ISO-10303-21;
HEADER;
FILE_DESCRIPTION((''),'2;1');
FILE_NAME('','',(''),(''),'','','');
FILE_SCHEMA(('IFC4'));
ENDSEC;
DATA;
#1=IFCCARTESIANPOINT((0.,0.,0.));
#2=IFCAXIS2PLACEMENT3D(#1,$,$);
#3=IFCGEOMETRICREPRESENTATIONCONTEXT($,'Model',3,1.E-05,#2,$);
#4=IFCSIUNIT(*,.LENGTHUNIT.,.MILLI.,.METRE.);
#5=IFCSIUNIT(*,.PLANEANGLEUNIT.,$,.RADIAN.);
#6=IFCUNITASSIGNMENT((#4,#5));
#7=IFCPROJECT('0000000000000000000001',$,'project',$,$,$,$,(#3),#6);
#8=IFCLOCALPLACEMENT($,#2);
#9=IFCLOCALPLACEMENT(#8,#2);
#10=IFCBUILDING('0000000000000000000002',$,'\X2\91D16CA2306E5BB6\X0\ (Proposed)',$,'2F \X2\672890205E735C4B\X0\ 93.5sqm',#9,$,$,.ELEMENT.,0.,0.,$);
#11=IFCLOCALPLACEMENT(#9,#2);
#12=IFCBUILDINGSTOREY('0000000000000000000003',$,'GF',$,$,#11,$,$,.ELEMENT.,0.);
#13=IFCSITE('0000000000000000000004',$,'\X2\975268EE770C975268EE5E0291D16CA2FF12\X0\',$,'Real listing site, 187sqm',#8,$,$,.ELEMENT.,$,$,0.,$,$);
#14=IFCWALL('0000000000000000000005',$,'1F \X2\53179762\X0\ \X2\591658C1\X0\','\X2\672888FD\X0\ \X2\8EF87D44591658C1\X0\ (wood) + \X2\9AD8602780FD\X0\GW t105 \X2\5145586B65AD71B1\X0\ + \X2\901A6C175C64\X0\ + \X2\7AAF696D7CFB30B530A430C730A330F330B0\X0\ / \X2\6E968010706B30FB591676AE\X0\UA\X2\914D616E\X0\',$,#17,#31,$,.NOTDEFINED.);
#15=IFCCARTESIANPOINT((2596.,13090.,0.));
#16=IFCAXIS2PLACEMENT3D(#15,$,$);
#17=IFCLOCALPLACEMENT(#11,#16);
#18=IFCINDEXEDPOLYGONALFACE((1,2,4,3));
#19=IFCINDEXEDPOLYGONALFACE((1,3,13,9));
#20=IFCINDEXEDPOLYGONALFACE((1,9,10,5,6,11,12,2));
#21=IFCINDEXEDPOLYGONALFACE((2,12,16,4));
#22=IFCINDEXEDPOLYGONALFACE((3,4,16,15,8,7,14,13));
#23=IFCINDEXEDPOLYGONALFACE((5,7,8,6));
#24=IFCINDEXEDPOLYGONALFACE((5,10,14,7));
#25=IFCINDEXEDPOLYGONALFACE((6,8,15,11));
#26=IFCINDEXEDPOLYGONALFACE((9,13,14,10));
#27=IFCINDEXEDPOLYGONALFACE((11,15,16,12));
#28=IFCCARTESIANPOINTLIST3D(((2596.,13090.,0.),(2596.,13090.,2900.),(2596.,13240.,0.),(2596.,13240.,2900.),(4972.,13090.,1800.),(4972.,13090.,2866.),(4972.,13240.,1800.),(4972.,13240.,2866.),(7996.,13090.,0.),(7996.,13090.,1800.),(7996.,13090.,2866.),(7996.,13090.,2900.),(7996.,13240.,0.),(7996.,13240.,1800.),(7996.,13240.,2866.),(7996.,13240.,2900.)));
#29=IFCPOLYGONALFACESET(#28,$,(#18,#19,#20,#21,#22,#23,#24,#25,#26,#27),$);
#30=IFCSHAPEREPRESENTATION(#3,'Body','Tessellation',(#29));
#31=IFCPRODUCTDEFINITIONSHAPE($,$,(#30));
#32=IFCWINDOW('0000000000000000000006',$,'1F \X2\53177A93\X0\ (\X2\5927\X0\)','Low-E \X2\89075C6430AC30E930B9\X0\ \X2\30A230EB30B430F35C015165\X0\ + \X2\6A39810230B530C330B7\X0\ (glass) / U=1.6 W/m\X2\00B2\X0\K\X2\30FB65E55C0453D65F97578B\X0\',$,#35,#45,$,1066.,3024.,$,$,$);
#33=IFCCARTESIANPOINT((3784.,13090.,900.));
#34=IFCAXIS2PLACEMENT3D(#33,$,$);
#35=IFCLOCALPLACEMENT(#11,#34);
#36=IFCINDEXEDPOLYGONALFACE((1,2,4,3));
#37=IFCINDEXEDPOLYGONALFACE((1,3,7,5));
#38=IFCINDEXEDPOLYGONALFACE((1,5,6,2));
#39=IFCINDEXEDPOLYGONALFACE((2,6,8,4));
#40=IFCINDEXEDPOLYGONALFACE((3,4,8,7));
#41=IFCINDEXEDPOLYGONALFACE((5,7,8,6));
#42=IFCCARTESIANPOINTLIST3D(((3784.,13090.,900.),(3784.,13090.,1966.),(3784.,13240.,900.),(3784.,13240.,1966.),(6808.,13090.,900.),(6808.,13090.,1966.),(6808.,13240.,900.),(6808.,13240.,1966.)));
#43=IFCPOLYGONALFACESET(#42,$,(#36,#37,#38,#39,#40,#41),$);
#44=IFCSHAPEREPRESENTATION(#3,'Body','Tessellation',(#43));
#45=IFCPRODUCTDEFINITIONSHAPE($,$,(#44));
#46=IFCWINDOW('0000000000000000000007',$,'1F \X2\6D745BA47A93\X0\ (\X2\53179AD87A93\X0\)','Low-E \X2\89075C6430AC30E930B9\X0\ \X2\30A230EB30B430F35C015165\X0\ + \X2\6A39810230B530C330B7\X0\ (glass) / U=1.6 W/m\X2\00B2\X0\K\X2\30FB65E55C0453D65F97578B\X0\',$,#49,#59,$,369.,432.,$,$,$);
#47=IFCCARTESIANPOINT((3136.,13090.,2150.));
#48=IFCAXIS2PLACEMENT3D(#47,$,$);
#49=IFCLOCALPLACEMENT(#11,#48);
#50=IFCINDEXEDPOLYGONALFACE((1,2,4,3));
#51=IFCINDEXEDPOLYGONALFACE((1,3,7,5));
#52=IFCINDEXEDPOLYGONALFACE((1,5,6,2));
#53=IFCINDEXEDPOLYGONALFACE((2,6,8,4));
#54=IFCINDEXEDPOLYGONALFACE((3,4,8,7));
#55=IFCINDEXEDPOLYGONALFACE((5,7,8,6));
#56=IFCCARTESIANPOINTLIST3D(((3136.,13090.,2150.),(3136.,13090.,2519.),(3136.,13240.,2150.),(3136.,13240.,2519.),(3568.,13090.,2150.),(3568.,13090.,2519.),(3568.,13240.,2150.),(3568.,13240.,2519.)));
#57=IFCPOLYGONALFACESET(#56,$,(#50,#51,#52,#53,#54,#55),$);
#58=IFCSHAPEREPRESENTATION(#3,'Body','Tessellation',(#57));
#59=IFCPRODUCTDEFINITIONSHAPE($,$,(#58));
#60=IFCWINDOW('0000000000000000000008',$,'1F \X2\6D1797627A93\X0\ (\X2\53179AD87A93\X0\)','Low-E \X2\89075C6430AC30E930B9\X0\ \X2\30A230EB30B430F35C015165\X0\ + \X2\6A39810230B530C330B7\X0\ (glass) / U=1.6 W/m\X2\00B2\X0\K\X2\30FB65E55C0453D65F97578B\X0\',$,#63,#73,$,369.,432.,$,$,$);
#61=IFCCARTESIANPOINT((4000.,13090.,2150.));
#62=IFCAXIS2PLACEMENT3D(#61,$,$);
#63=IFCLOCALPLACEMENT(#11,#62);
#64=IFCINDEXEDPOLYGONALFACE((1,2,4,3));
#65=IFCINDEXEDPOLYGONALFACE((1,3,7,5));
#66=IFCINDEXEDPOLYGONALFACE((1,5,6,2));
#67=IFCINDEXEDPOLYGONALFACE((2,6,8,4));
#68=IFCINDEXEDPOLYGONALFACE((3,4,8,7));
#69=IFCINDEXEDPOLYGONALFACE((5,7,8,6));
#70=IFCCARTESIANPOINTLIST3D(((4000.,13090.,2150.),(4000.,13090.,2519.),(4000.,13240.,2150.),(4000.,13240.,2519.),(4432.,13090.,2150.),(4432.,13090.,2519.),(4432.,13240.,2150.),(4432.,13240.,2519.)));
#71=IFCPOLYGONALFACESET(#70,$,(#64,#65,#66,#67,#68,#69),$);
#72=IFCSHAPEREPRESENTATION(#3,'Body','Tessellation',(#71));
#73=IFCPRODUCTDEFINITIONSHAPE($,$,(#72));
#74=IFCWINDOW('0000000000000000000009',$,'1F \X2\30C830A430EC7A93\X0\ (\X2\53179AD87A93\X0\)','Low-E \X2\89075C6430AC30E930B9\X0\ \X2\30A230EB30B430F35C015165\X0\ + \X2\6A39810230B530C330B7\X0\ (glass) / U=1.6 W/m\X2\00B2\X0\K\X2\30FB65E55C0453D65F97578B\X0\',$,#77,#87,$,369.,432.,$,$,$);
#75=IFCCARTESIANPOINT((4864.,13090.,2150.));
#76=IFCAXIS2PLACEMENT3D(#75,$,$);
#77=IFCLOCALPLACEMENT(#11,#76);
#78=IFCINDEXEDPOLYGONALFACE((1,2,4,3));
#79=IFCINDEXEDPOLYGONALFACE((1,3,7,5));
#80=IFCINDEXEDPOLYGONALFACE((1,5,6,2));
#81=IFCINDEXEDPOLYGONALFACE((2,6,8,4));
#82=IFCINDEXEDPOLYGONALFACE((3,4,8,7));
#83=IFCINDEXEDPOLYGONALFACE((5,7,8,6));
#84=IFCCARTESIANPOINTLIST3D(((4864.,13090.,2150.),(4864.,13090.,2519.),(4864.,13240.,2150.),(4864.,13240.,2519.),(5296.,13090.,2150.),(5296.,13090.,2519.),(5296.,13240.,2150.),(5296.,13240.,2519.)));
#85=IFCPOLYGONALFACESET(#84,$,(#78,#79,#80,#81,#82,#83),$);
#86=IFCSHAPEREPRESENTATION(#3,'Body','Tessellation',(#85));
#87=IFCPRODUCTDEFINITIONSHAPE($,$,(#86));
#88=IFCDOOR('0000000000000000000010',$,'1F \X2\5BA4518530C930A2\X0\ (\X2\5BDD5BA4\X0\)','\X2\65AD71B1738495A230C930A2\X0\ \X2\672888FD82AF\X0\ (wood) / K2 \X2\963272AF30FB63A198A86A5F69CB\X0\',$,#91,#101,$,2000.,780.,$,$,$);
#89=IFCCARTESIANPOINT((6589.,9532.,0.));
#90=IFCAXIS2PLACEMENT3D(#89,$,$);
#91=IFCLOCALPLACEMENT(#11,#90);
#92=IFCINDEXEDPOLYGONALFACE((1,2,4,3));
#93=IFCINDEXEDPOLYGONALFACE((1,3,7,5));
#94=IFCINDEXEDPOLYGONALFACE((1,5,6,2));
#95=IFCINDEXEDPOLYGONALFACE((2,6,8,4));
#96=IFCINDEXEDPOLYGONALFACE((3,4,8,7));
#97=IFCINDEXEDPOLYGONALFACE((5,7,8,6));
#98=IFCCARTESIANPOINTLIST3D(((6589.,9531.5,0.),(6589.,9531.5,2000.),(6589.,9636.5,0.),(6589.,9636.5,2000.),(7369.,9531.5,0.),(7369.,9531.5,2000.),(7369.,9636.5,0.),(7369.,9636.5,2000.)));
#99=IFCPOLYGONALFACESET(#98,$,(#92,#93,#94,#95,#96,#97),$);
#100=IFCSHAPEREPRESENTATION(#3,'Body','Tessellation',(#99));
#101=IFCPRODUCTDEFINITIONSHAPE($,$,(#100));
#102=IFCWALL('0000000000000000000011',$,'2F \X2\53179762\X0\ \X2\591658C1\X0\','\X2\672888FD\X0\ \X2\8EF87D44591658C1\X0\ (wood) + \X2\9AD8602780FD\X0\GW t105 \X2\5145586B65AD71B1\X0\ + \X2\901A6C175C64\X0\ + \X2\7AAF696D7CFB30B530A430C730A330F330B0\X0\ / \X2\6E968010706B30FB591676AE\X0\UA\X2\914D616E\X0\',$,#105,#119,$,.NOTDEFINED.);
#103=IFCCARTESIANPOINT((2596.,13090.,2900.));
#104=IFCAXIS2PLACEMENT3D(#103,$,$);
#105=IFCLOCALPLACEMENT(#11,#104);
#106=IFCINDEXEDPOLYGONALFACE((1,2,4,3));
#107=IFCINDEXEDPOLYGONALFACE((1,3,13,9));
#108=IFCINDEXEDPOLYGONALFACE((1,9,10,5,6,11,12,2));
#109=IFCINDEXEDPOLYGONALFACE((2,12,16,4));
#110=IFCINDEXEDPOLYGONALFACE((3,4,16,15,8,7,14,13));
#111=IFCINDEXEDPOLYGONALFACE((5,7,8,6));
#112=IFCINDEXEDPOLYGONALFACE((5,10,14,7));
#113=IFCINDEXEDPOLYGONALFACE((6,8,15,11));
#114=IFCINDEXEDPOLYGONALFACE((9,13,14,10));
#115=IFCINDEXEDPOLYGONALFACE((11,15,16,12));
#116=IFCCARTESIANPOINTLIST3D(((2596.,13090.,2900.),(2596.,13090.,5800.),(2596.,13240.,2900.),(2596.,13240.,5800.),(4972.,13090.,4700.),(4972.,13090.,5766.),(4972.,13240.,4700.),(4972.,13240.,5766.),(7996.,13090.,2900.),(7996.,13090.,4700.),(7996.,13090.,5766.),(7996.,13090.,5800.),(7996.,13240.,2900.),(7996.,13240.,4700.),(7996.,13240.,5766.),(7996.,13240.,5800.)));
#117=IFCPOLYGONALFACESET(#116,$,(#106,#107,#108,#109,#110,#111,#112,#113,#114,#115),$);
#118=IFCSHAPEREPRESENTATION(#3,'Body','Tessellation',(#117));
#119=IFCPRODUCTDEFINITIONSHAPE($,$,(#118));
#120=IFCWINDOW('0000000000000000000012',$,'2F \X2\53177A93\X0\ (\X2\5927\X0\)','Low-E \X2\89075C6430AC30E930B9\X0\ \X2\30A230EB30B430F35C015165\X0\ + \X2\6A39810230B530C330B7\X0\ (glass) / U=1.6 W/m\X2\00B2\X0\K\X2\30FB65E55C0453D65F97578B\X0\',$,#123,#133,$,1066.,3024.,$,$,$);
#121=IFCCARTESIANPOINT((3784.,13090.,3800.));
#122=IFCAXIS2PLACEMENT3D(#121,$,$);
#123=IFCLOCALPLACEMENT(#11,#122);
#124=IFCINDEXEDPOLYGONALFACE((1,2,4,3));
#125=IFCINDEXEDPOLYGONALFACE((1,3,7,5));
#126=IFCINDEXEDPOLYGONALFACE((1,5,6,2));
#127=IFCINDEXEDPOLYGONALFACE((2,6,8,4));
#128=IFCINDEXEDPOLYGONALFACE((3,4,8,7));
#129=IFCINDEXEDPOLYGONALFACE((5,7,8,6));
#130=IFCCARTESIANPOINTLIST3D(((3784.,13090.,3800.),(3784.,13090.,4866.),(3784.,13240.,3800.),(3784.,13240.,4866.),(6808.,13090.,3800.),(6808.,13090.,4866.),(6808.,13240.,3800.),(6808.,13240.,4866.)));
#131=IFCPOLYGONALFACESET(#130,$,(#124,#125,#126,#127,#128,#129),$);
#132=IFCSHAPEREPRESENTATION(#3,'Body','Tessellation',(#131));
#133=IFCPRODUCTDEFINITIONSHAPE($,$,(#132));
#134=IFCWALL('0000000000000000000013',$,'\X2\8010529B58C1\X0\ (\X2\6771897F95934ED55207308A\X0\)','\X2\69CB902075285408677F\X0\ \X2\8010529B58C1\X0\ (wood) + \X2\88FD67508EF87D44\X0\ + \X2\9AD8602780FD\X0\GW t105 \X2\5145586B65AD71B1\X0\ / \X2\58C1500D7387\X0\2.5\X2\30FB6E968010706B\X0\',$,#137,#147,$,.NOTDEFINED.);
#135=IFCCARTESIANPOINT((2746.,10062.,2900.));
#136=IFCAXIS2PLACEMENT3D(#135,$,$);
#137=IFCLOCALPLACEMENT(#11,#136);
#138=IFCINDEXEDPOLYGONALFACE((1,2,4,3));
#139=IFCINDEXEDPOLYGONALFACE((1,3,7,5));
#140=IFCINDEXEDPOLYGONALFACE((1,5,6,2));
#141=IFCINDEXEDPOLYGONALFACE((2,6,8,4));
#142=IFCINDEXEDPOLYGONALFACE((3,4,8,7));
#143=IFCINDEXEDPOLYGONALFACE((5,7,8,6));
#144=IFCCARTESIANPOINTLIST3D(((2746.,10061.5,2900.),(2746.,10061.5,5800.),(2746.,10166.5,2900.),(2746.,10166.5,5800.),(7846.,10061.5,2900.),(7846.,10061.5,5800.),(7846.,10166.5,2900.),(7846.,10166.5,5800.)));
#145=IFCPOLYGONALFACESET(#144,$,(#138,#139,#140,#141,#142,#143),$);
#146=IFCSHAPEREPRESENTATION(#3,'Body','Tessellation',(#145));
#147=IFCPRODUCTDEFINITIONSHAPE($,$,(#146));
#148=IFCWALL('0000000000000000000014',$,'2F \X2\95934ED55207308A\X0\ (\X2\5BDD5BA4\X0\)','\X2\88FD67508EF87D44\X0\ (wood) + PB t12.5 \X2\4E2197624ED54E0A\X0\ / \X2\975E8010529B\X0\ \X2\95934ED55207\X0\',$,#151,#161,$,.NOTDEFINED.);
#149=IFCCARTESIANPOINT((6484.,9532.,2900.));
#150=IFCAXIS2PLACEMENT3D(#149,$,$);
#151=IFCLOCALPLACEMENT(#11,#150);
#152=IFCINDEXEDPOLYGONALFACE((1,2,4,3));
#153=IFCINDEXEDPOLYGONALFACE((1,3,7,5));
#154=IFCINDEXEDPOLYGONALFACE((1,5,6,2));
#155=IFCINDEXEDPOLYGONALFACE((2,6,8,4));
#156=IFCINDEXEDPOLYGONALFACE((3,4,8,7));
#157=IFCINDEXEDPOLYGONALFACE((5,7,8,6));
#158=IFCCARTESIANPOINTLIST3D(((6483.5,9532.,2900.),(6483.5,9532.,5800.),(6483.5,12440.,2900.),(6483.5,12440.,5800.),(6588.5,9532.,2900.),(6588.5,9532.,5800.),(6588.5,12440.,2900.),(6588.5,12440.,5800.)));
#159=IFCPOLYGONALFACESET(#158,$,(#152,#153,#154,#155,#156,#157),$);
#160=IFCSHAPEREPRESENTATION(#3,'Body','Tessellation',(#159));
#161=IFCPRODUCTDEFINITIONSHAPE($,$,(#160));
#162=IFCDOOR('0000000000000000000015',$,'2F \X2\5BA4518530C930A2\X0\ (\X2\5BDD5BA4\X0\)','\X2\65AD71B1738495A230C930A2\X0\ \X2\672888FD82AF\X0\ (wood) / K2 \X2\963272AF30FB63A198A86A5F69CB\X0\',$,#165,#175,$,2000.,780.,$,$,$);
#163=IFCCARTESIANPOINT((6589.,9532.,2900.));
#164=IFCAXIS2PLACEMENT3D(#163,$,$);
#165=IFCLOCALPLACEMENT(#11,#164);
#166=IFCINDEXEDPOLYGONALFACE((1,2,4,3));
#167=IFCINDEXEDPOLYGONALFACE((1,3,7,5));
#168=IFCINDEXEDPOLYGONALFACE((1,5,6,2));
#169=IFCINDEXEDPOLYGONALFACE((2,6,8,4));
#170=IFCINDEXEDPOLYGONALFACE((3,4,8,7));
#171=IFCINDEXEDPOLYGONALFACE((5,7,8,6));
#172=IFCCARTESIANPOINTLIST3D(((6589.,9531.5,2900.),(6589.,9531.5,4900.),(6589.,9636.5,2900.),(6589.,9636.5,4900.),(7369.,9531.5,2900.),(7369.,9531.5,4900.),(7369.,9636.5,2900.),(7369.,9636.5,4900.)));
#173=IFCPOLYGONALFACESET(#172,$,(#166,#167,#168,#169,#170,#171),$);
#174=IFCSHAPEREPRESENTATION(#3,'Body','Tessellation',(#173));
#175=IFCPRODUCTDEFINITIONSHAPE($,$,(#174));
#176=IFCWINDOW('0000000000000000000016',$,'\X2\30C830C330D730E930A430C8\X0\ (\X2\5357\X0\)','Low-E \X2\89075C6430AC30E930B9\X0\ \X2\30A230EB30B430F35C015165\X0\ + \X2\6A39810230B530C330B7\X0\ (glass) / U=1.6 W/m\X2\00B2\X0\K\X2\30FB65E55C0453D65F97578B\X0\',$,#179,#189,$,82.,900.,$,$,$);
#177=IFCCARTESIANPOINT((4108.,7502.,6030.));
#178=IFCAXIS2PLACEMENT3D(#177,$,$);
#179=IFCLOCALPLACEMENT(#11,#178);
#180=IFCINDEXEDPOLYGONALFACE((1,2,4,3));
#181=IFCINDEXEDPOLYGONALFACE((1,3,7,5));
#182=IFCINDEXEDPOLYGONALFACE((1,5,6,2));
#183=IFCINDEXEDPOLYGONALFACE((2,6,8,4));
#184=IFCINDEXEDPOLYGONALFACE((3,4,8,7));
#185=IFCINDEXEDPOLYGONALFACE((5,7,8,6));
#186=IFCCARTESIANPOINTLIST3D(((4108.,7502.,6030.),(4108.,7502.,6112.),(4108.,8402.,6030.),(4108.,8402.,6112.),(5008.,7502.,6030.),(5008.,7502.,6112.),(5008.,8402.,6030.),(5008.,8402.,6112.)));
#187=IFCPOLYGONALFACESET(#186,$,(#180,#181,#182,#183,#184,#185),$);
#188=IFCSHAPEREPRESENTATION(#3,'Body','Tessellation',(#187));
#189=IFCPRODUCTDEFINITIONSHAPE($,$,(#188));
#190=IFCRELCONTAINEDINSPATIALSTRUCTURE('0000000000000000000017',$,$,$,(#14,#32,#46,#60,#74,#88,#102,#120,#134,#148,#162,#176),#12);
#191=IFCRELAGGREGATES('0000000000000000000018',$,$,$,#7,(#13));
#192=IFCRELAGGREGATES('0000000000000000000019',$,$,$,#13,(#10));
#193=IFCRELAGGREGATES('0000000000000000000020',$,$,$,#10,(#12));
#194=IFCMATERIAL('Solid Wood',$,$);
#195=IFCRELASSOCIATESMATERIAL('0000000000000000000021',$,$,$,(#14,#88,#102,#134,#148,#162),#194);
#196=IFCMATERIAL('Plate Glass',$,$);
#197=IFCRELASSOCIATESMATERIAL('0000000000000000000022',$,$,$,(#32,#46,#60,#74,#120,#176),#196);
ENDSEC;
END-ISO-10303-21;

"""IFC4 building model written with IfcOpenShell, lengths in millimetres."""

from ifc_helpers import new_model, si_unit, frame, frame_2d, origin, place, context, project, spatial, rectangle, extrude, material, element, fill, save


model = new_model("IFC4")

# Units and contexts
model_context = context("Model", 3, precision=1e-05, world=origin())
ifc_project = project(units=[si_unit("LENGTHUNIT", "METRE", prefix="MILLI"), si_unit("PLANEANGLEUNIT", "RADIAN")], contexts=[model_context])

# Site, building, storey
site_placement = place(None, origin())
site = spatial("IfcSite", under=ifc_project, at=site_placement, Name="青森県青森市金沢２", ObjectType="Real listing site, 187sqm", CompositionType="ELEMENT", RefElevation=0.0)
building_placement = place(site_placement, origin())
building = spatial("IfcBuilding", under=site, at=building_placement, Name="金沢の家 (Proposed)", ObjectType="2F 木造平屋 93.5sqm", CompositionType="ELEMENT", ElevationOfRefHeight=0.0, ElevationOfTerrain=0.0)
storey_placement = place(building_placement, origin())
storey = spatial("IfcBuildingStorey", under=building, at=storey_placement, Name="GF", CompositionType="ELEMENT", Elevation=0.0)

# Wall, openings, windows
ifc_material_1 = material(Name="Solid Wood")
wall_1_placement = place(storey_placement, frame((2596.0, 13090.0, 0.0)))
wall_1 = element("IfcWall", 1, at=wall_1_placement, inside=storey, material=ifc_material_1, Name="1F 北面 外壁", Description="木製 軸組外壁 (wood) + 高性能GW t105 充填断熱 + 通気層 + 窯業系サイディング / 準耐火・外皮UA配慮", PredefinedType="NOTDEFINED", context=model_context, shape_type="SweptSolid", body=[
    extrude(rectangle(XDim=5400.0, YDim=150.0, at=frame_2d((2700.0, 75.0))), frame((2596.0, 13090.0, 0.0)), (0.0, 0.0, 1.0), 2900.0),
])
opening_1_placement = place(storey_placement, frame((3784.0, 13090.0, 900.0)))
opening_1 = element("IfcOpeningElement", 2, at=opening_1_placement, cuts=wall_1, PredefinedType="NOTDEFINED", context=model_context, shape_type="SweptSolid", body=[
    extrude(rectangle(XDim=3024.0, YDim=150.0, at=frame_2d((1512.0, 75.0))), frame((3784.0, 13090.0, 900.0)), (0.0, 0.0, 1.0), 1066.0),
])
opening_2_placement = place(storey_placement, frame((3136.0, 13090.0, 2150.0)))
opening_2 = element("IfcOpeningElement", 3, at=opening_2_placement, cuts=wall_1, PredefinedType="NOTDEFINED", context=model_context, shape_type="SweptSolid", body=[
    extrude(rectangle(XDim=432.0, YDim=150.0, at=frame_2d((216.0, 75.0))), frame((3136.0, 13090.0, 2150.0)), (0.0, 0.0, 1.0), 369.0),
])
opening_3_placement = place(storey_placement, frame((4000.0, 13090.0, 2150.0)))
opening_3 = element("IfcOpeningElement", 4, at=opening_3_placement, cuts=wall_1, PredefinedType="NOTDEFINED", context=model_context, shape_type="SweptSolid", body=[
    extrude(rectangle(XDim=432.0, YDim=150.0, at=frame_2d((216.0, 75.0))), frame((4000.0, 13090.0, 2150.0)), (0.0, 0.0, 1.0), 369.0),
])
opening_4_placement = place(storey_placement, frame((4864.0, 13090.0, 2150.0)))
opening_4 = element("IfcOpeningElement", 5, at=opening_4_placement, cuts=wall_1, PredefinedType="NOTDEFINED", context=model_context, shape_type="SweptSolid", body=[
    extrude(rectangle(XDim=432.0, YDim=150.0, at=frame_2d((216.0, 75.0))), frame((4864.0, 13090.0, 2150.0)), (0.0, 0.0, 1.0), 369.0),
])
ifc_material_2 = material(Name="Plate Glass")
window_1_placement = place(storey_placement, frame((3784.0, 13090.0, 900.0)))
window_1 = element("IfcWindow", 6, at=window_1_placement, inside=storey, material=ifc_material_2, Name="1F 北窓 (大)", Description="Low-E 複層ガラス アルゴン封入 + 樹脂サッシ (glass) / U=1.6 W/m²K・日射取得型", OverallHeight=1066.0, OverallWidth=3024.0, context=model_context, shape_type="SweptSolid", body=[
    extrude(rectangle(XDim=3024.0, YDim=150.0, at=frame_2d((1512.0, 75.0))), frame((3784.0, 13090.0, 900.0)), (0.0, 0.0, 1.0), 1066.0),
])
fill(opening_1, window_1)
window_2_placement = place(storey_placement, frame((3136.0, 13090.0, 2150.0)))
window_2 = element("IfcWindow", 7, at=window_2_placement, inside=storey, material=ifc_material_2, Name="1F 浴室窓 (北高窓)", Description="Low-E 複層ガラス アルゴン封入 + 樹脂サッシ (glass) / U=1.6 W/m²K・日射取得型", OverallHeight=369.0, OverallWidth=432.0, context=model_context, shape_type="SweptSolid", body=[
    extrude(rectangle(XDim=432.0, YDim=150.0, at=frame_2d((216.0, 75.0))), frame((3136.0, 13090.0, 2150.0)), (0.0, 0.0, 1.0), 369.0),
])
fill(opening_2, window_2)
window_3_placement = place(storey_placement, frame((4000.0, 13090.0, 2150.0)))
window_3 = element("IfcWindow", 8, at=window_3_placement, inside=storey, material=ifc_material_2, Name="1F 洗面窓 (北高窓)", Description="Low-E 複層ガラス アルゴン封入 + 樹脂サッシ (glass) / U=1.6 W/m²K・日射取得型", OverallHeight=369.0, OverallWidth=432.0, context=model_context, shape_type="SweptSolid", body=[
    extrude(rectangle(XDim=432.0, YDim=150.0, at=frame_2d((216.0, 75.0))), frame((4000.0, 13090.0, 2150.0)), (0.0, 0.0, 1.0), 369.0),
])
fill(opening_3, window_3)
window_4_placement = place(storey_placement, frame((4864.0, 13090.0, 2150.0)))
window_4 = element("IfcWindow", 9, at=window_4_placement, inside=storey, material=ifc_material_2, Name="1F トイレ窓 (北高窓)", Description="Low-E 複層ガラス アルゴン封入 + 樹脂サッシ (glass) / U=1.6 W/m²K・日射取得型", OverallHeight=369.0, OverallWidth=432.0, context=model_context, shape_type="SweptSolid", body=[
    extrude(rectangle(XDim=432.0, YDim=150.0, at=frame_2d((216.0, 75.0))), frame((4864.0, 13090.0, 2150.0)), (0.0, 0.0, 1.0), 369.0),
])
fill(opening_4, window_4)

# Door
door_1_placement = place(storey_placement, frame((6589.0, 9532.0, 0.0)))
element("IfcDoor", 10, at=door_1_placement, inside=storey, material=ifc_material_1, Name="1F 室内ドア (寝室)", Description="断熱玄関ドア 木製芯 (wood) / K2 防犯・採風機構", OverallHeight=2000.0, OverallWidth=780.0, context=model_context, shape_type="SweptSolid", body=[
    extrude(rectangle(XDim=780.0, YDim=105.0, at=frame_2d((390.0, 52.0))), frame((6589.0, 9532.0, 0.0)), (0.0, 0.0, 1.0), 2000.0),
])

# Wall, opening, window
wall_2_placement = place(storey_placement, frame((2596.0, 13090.0, 2900.0)))
wall_2 = element("IfcWall", 11, at=wall_2_placement, inside=storey, material=ifc_material_1, Name="2F 北面 外壁", Description="木製 軸組外壁 (wood) + 高性能GW t105 充填断熱 + 通気層 + 窯業系サイディング / 準耐火・外皮UA配慮", PredefinedType="NOTDEFINED", context=model_context, shape_type="SweptSolid", body=[
    extrude(rectangle(XDim=5400.0, YDim=150.0, at=frame_2d((2700.0, 75.0))), frame((2596.0, 13090.0, 2900.0)), (0.0, 0.0, 1.0), 2900.0),
])
opening_5_placement = place(storey_placement, frame((3784.0, 13090.0, 3800.0)))
opening_5 = element("IfcOpeningElement", 12, at=opening_5_placement, cuts=wall_2, PredefinedType="NOTDEFINED", context=model_context, shape_type="SweptSolid", body=[
    extrude(rectangle(XDim=3024.0, YDim=150.0, at=frame_2d((1512.0, 75.0))), frame((3784.0, 13090.0, 3800.0)), (0.0, 0.0, 1.0), 1066.0),
])
window_5_placement = place(storey_placement, frame((3784.0, 13090.0, 3800.0)))
window_5 = element("IfcWindow", 13, at=window_5_placement, inside=storey, material=ifc_material_2, Name="2F 北窓 (大)", Description="Low-E 複層ガラス アルゴン封入 + 樹脂サッシ (glass) / U=1.6 W/m²K・日射取得型", OverallHeight=1066.0, OverallWidth=3024.0, context=model_context, shape_type="SweptSolid", body=[
    extrude(rectangle(XDim=3024.0, YDim=150.0, at=frame_2d((1512.0, 75.0))), frame((3784.0, 13090.0, 3800.0)), (0.0, 0.0, 1.0), 1066.0),
])
fill(opening_5, window_5)

# Walls
wall_3_placement = place(storey_placement, frame((2746.0, 10062.0, 2900.0)))
element("IfcWall", 14, at=wall_3_placement, inside=storey, material=ifc_material_1, Name="耐力壁 (東西間仕切り)", Description="構造用合板 耐力壁 (wood) + 製材軸組 + 高性能GW t105 充填断熱 / 壁倍率2.5・準耐火", PredefinedType="NOTDEFINED", context=model_context, shape_type="SweptSolid", body=[
    extrude(rectangle(XDim=5100.0, YDim=105.0, at=frame_2d((2550.0, 52.0))), frame((2746.0, 10062.0, 2900.0)), (0.0, 0.0, 1.0), 2900.0),
])
wall_4_placement = place(storey_placement, frame((6484.0, 9532.0, 2900.0)))
element("IfcWall", 15, at=wall_4_placement, inside=storey, material=ifc_material_1, Name="2F 間仕切り (寝室)", Description="製材軸組 (wood) + PB t12.5 両面仕上 / 非耐力 間仕切", PredefinedType="NOTDEFINED", context=model_context, shape_type="SweptSolid", body=[
    extrude(rectangle(XDim=105.0, YDim=2908.0, at=frame_2d((52.0, 1454.0))), frame((6484.0, 9532.0, 2900.0)), (0.0, 0.0, 1.0), 2900.0),
])

# Door
door_2_placement = place(storey_placement, frame((6589.0, 9532.0, 2900.0)))
element("IfcDoor", 16, at=door_2_placement, inside=storey, material=ifc_material_1, Name="2F 室内ドア (寝室)", Description="断熱玄関ドア 木製芯 (wood) / K2 防犯・採風機構", OverallHeight=2000.0, OverallWidth=780.0, context=model_context, shape_type="SweptSolid", body=[
    extrude(rectangle(XDim=780.0, YDim=105.0, at=frame_2d((390.0, 52.0))), frame((6589.0, 9532.0, 2900.0)), (0.0, 0.0, 1.0), 2000.0),
])

# Window
window_6_placement = place(storey_placement, frame((4108.0, 7502.0, 6030.0)))
element("IfcWindow", 17, at=window_6_placement, inside=storey, material=ifc_material_2, Name="トップライト (南)", Description="Low-E 複層ガラス アルゴン封入 + 樹脂サッシ (glass) / U=1.6 W/m²K・日射取得型", OverallHeight=82.0, OverallWidth=900.0, context=model_context, shape_type="SweptSolid", body=[
    extrude(rectangle(XDim=900.0, YDim=900.0, at=frame_2d((450.0, 450.0))), frame((4108.0, 7502.0, 6030.0)), (0.0, 0.0, 1.0), 82.0),
])

save(model, "model.ifc")
